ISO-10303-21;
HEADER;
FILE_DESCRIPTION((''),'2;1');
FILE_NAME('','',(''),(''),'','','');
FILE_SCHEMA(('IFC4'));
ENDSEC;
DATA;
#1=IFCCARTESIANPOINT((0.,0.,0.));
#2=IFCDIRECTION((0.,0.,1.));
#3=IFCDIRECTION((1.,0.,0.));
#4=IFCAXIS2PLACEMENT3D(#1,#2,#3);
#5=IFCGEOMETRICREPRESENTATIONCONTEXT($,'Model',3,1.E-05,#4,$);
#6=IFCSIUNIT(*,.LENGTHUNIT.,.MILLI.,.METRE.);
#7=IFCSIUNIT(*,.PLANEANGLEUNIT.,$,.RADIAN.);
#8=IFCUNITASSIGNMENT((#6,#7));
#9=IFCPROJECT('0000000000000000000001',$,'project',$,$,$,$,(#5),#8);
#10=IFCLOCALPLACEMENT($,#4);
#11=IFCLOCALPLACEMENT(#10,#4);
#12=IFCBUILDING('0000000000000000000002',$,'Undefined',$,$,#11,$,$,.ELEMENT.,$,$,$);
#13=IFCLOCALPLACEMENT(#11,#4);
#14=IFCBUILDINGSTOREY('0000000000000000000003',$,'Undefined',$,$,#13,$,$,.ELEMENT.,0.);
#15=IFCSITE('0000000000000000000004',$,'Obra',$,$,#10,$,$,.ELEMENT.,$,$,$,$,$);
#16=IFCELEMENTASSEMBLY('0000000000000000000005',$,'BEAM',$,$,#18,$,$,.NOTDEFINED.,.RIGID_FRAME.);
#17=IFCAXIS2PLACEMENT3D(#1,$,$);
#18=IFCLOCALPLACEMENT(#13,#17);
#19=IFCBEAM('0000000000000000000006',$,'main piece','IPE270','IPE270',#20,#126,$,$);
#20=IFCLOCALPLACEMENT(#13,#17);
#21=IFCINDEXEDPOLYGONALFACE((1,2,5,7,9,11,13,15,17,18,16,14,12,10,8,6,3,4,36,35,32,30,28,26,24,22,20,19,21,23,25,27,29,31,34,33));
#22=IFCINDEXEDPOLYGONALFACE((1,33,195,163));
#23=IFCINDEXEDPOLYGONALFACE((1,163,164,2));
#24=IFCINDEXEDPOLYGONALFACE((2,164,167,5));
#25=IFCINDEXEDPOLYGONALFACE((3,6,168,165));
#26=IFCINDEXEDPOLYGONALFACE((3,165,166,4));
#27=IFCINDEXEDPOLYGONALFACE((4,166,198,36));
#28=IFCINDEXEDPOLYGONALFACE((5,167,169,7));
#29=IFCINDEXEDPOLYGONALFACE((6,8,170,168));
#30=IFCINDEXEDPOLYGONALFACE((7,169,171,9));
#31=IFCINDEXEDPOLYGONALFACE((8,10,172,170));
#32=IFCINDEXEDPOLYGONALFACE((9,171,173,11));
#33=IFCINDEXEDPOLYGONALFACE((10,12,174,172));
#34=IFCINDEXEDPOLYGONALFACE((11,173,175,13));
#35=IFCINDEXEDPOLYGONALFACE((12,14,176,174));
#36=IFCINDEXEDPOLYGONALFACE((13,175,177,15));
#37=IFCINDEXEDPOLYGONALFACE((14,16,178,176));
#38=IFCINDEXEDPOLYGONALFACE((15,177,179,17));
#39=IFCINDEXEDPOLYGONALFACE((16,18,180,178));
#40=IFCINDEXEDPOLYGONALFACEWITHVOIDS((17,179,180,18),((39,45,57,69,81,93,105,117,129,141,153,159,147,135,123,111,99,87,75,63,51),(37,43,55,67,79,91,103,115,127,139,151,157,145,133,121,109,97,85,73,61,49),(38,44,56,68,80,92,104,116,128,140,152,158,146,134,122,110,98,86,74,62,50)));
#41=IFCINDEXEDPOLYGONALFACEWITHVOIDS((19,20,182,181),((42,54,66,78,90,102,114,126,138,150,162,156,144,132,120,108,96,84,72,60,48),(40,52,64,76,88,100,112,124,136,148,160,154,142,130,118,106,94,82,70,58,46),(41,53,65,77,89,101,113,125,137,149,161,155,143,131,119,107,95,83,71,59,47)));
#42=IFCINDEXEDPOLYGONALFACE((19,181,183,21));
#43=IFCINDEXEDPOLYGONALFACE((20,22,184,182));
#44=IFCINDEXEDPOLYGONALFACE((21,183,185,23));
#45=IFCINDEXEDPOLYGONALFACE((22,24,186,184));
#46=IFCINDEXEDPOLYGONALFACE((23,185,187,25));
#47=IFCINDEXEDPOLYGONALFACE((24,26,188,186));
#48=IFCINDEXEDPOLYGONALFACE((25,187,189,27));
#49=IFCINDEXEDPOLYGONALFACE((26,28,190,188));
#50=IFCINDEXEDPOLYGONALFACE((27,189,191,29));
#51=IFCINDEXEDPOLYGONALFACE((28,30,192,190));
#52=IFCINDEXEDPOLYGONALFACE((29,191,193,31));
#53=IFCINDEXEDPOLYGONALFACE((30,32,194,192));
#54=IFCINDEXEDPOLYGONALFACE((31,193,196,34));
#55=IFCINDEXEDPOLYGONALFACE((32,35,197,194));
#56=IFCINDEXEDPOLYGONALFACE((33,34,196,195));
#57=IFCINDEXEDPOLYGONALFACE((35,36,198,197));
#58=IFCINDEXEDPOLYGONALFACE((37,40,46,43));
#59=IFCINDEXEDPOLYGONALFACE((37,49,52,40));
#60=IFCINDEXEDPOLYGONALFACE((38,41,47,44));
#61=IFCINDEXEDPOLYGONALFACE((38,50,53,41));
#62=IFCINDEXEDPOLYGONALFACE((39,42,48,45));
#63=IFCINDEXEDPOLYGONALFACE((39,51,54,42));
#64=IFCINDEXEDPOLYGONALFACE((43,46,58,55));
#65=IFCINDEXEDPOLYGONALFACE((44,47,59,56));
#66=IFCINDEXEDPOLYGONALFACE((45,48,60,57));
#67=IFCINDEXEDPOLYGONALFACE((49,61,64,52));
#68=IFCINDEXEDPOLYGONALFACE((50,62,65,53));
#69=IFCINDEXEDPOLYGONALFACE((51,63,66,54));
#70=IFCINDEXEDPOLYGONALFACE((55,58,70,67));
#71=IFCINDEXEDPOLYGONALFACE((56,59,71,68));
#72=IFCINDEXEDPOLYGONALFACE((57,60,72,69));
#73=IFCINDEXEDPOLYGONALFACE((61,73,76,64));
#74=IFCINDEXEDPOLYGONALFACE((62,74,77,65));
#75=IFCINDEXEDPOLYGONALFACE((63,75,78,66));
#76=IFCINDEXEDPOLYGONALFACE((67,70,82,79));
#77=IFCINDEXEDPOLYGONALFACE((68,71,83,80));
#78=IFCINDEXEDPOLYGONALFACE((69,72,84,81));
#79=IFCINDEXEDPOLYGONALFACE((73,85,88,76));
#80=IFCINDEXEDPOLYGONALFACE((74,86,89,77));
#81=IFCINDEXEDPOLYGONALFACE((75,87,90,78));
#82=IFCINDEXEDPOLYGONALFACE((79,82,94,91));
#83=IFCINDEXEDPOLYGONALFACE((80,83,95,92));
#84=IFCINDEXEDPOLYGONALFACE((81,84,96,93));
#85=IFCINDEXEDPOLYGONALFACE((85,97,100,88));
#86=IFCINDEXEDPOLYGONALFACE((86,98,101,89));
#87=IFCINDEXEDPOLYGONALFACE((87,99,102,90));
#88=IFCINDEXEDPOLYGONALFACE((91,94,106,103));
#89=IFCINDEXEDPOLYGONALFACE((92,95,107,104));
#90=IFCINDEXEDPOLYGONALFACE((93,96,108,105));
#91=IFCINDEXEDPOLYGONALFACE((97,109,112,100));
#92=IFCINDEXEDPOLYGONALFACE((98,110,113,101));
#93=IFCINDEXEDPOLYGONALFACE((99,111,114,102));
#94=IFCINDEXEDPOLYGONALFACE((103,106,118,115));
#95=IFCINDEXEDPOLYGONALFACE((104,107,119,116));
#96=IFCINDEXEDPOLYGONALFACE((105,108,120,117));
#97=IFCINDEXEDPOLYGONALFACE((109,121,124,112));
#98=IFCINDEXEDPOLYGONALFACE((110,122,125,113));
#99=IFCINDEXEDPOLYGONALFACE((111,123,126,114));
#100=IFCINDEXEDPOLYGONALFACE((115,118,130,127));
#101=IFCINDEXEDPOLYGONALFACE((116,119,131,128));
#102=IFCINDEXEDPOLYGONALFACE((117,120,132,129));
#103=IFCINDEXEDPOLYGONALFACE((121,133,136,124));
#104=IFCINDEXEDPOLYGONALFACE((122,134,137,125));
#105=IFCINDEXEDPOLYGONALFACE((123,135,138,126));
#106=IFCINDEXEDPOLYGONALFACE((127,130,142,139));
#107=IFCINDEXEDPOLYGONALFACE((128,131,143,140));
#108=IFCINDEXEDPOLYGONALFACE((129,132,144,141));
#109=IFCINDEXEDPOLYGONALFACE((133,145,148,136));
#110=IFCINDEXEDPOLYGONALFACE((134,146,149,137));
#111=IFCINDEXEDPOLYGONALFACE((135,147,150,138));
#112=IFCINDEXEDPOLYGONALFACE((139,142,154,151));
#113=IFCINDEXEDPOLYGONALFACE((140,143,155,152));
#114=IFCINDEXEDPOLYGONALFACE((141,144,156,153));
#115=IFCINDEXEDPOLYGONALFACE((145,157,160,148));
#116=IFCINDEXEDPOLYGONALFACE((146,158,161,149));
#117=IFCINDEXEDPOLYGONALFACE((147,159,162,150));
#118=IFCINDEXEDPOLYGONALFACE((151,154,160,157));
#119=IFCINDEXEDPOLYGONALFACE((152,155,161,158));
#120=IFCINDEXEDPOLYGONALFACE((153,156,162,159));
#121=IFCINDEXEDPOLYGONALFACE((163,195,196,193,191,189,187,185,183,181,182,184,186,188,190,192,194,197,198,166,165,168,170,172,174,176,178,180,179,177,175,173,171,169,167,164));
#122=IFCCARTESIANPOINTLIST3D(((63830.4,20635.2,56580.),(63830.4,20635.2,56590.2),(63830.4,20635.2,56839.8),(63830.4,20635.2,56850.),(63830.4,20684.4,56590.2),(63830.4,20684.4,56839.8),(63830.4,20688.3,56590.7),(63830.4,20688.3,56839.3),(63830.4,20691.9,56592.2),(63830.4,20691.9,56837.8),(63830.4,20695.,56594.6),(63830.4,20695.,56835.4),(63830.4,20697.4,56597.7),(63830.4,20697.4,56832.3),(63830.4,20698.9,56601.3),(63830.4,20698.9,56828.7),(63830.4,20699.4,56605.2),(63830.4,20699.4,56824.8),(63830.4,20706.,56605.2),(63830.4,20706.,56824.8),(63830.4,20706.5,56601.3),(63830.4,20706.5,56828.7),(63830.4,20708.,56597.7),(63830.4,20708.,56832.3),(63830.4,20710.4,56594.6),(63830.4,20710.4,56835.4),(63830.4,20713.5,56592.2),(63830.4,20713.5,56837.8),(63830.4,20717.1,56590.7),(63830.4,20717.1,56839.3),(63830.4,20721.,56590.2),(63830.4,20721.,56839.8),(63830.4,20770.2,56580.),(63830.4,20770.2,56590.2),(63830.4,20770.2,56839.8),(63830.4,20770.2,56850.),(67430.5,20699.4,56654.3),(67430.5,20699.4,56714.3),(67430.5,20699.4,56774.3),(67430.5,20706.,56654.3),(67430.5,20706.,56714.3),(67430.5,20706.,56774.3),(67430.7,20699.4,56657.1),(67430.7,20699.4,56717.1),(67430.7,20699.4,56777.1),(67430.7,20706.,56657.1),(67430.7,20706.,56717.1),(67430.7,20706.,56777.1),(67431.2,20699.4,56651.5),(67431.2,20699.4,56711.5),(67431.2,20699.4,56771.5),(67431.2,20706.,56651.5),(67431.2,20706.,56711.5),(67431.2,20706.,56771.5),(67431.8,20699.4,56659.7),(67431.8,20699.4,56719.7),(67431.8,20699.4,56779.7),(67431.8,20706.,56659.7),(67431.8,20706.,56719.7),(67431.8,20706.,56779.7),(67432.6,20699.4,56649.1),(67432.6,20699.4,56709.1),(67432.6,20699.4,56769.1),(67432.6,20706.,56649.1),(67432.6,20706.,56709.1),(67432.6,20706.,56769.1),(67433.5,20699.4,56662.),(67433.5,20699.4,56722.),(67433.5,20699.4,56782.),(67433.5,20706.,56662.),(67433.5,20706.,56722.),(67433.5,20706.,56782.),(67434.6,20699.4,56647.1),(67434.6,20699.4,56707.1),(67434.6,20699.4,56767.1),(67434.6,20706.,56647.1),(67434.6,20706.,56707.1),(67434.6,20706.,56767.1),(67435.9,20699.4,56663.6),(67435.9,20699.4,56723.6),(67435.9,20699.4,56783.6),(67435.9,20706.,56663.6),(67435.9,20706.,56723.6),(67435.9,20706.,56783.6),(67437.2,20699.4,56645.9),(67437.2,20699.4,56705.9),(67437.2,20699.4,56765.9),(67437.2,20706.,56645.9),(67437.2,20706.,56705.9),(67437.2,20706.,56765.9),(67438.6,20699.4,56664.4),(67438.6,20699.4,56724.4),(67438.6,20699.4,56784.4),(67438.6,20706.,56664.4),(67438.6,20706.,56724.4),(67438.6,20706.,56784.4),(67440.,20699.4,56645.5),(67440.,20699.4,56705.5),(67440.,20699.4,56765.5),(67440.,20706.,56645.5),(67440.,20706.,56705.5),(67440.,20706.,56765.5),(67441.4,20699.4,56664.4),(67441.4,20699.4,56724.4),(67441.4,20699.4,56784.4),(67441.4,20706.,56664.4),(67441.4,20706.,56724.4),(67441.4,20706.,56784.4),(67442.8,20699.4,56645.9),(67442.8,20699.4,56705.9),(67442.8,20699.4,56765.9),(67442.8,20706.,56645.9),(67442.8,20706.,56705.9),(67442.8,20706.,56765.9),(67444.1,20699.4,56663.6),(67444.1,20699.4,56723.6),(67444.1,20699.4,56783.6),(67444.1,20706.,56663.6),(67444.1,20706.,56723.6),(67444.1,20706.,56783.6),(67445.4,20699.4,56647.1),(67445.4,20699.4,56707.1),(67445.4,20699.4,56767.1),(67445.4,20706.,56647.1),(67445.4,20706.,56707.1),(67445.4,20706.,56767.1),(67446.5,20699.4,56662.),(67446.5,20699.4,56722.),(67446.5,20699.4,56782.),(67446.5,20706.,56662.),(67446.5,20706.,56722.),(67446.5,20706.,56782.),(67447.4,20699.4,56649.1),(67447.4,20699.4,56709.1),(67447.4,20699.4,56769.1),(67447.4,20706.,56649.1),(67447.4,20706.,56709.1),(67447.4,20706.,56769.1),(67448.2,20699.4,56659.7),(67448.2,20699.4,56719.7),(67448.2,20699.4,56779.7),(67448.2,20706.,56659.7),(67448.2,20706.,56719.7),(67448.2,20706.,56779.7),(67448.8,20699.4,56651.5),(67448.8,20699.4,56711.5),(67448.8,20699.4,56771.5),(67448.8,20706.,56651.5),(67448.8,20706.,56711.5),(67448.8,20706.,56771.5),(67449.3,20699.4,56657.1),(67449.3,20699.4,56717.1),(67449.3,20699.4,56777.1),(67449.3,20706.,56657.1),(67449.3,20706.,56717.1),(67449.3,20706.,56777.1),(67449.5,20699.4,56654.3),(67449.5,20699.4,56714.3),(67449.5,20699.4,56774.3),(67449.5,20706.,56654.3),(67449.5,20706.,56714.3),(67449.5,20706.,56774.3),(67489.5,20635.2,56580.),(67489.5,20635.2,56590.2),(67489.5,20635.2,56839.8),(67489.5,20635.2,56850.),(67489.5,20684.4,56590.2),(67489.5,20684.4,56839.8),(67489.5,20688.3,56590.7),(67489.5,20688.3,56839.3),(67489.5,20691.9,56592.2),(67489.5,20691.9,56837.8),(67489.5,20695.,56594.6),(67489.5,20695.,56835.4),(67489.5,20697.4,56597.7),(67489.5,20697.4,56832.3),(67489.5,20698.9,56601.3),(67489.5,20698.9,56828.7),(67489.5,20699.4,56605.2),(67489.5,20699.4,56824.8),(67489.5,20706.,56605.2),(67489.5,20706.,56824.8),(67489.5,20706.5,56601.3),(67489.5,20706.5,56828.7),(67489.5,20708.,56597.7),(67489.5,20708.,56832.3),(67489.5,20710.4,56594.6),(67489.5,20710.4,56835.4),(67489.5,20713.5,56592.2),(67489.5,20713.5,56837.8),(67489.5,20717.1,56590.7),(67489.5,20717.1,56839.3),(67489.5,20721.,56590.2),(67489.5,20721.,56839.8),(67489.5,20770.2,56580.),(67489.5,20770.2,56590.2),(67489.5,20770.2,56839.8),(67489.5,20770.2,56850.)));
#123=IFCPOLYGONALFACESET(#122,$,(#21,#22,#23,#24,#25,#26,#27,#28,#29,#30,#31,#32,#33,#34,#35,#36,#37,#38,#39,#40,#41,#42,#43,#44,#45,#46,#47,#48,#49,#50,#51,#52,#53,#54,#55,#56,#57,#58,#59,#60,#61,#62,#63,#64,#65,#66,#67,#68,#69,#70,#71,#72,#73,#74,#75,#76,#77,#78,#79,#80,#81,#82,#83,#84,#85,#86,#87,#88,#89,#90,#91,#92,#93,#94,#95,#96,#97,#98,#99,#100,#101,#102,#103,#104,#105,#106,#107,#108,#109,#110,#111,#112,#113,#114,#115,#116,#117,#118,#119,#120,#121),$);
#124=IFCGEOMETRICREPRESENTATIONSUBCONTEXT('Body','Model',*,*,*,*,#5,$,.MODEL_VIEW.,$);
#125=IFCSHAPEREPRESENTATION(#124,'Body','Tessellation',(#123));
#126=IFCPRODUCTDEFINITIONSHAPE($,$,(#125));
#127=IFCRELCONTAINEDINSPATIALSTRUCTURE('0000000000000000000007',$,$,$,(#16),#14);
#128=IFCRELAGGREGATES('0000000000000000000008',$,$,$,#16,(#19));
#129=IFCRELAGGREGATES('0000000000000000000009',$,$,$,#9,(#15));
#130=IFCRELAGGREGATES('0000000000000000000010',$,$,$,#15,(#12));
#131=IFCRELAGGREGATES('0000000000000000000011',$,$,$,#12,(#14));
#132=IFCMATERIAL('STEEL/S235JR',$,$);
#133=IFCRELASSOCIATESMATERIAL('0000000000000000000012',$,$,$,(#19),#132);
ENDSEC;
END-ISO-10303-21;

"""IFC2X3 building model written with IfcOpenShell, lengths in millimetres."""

from ifc_helpers import new_model, si_unit, frame, origin_with_axes, origin_2d_with_axis, place, context, subcontext, project, spatial, circle, i_section, extrude, clip, halfspace, source, transform, mapped, material, element, aggregate, save


model = new_model("IFC2X3")

# Units and contexts
model_context = context("Model", 3, precision=1e-05, world=origin_with_axes())
body_context = subcontext(model_context, "Body", "Model", "MODEL_VIEW")
ifc_project = project(units=[si_unit("LENGTHUNIT", "METRE", prefix="MILLI"), si_unit("PLANEANGLEUNIT", "RADIAN")], contexts=[model_context])

# Site, building, storey
site_placement = place(None, origin_with_axes())
site = spatial("IfcSite", under=ifc_project, at=site_placement, Name="Obra", CompositionType="ELEMENT")
building_placement = place(site_placement, origin_with_axes())
building = spatial("IfcBuilding", under=site, at=building_placement, Name="Undefined", CompositionType="ELEMENT")
storey_placement = place(building_placement, origin_with_axes())
storey = spatial("IfcBuildingStorey", under=building, at=storey_placement, Name="Undefined", CompositionType="ELEMENT", Elevation=0.0)

# Shared definitions
ifc_material_1 = material(Name="STEEL/S235JR")

# Element assembly, beam, opening
assembly_1_placement = place(storey_placement, origin_with_axes())
assembly_1 = element("IfcElementAssembly", 1, at=assembly_1_placement, inside=storey, Name="BEAM", AssemblyPlace="NOTDEFINED", PredefinedType="RIGID_FRAME")
beam_1_placement = place(assembly_1_placement, frame((63830.4, 20702.7, 56715.0), z_axis=(0.0, 0.0, 1.0), x_axis=(1.0, 0.000002, 0.0)))
beam_1 = element("IfcBeam", 2, at=beam_1_placement, material=ifc_material_1, Name="main piece", Description="IPE270", ObjectType="IPE270", context=body_context, shape_type="Clipping", body=[
    clip(extrude(i_section(OverallWidth=135.0, OverallDepth=270.0, WebThickness=6.6, FlangeThickness=10.2, FilletRadius=15.0, at=origin_2d_with_axis()), frame((3859.9, 0.0, 0.0), z_axis=(-1.0, 0.0, 0.0), x_axis=(0.0, -1.0, 0.0)), (0.0, 0.0, 1.0), 3859.9), halfspace(frame((3659.1, -60.0, -120.0), z_axis=(1.0, 0.000017, 0.0), x_axis=(0.0, 0.0, 1.0)), False)),
])
shared_shape_1 = source(origin_with_axes(), body_context, "Body", "SweptSolid", [
    extrude(circle(Radius=9.5, at=origin_2d_with_axis()), frame((0.0, -3.4, 0.0), z_axis=(0.0, 1.0, 0.0), x_axis=(1.0, 0.0, 0.0)), (0.0, 0.0, 1.0), 6.8),
])
opening_1_placement = place(assembly_1_placement, frame((67490.0, 20702.7, 56835.0), z_axis=(-1.0, 0.0, 0.0), x_axis=(0.0, 0.0, -1.0)))
element("IfcOpeningElement", 3, at=opening_1_placement, cuts=beam_1, ObjectType="Opening", context=body_context, shape_type="MappedRepresentation", body=[
    mapped(shared_shape_1, transform((60.0, 0.0, 50.0))),
    mapped(shared_shape_1, transform((120.0, 0.0, 50.0))),
    mapped(shared_shape_1, transform((180.0, 0.0, 50.0))),
])
aggregate(assembly_1, [beam_1])

save(model, "model.ifc")
